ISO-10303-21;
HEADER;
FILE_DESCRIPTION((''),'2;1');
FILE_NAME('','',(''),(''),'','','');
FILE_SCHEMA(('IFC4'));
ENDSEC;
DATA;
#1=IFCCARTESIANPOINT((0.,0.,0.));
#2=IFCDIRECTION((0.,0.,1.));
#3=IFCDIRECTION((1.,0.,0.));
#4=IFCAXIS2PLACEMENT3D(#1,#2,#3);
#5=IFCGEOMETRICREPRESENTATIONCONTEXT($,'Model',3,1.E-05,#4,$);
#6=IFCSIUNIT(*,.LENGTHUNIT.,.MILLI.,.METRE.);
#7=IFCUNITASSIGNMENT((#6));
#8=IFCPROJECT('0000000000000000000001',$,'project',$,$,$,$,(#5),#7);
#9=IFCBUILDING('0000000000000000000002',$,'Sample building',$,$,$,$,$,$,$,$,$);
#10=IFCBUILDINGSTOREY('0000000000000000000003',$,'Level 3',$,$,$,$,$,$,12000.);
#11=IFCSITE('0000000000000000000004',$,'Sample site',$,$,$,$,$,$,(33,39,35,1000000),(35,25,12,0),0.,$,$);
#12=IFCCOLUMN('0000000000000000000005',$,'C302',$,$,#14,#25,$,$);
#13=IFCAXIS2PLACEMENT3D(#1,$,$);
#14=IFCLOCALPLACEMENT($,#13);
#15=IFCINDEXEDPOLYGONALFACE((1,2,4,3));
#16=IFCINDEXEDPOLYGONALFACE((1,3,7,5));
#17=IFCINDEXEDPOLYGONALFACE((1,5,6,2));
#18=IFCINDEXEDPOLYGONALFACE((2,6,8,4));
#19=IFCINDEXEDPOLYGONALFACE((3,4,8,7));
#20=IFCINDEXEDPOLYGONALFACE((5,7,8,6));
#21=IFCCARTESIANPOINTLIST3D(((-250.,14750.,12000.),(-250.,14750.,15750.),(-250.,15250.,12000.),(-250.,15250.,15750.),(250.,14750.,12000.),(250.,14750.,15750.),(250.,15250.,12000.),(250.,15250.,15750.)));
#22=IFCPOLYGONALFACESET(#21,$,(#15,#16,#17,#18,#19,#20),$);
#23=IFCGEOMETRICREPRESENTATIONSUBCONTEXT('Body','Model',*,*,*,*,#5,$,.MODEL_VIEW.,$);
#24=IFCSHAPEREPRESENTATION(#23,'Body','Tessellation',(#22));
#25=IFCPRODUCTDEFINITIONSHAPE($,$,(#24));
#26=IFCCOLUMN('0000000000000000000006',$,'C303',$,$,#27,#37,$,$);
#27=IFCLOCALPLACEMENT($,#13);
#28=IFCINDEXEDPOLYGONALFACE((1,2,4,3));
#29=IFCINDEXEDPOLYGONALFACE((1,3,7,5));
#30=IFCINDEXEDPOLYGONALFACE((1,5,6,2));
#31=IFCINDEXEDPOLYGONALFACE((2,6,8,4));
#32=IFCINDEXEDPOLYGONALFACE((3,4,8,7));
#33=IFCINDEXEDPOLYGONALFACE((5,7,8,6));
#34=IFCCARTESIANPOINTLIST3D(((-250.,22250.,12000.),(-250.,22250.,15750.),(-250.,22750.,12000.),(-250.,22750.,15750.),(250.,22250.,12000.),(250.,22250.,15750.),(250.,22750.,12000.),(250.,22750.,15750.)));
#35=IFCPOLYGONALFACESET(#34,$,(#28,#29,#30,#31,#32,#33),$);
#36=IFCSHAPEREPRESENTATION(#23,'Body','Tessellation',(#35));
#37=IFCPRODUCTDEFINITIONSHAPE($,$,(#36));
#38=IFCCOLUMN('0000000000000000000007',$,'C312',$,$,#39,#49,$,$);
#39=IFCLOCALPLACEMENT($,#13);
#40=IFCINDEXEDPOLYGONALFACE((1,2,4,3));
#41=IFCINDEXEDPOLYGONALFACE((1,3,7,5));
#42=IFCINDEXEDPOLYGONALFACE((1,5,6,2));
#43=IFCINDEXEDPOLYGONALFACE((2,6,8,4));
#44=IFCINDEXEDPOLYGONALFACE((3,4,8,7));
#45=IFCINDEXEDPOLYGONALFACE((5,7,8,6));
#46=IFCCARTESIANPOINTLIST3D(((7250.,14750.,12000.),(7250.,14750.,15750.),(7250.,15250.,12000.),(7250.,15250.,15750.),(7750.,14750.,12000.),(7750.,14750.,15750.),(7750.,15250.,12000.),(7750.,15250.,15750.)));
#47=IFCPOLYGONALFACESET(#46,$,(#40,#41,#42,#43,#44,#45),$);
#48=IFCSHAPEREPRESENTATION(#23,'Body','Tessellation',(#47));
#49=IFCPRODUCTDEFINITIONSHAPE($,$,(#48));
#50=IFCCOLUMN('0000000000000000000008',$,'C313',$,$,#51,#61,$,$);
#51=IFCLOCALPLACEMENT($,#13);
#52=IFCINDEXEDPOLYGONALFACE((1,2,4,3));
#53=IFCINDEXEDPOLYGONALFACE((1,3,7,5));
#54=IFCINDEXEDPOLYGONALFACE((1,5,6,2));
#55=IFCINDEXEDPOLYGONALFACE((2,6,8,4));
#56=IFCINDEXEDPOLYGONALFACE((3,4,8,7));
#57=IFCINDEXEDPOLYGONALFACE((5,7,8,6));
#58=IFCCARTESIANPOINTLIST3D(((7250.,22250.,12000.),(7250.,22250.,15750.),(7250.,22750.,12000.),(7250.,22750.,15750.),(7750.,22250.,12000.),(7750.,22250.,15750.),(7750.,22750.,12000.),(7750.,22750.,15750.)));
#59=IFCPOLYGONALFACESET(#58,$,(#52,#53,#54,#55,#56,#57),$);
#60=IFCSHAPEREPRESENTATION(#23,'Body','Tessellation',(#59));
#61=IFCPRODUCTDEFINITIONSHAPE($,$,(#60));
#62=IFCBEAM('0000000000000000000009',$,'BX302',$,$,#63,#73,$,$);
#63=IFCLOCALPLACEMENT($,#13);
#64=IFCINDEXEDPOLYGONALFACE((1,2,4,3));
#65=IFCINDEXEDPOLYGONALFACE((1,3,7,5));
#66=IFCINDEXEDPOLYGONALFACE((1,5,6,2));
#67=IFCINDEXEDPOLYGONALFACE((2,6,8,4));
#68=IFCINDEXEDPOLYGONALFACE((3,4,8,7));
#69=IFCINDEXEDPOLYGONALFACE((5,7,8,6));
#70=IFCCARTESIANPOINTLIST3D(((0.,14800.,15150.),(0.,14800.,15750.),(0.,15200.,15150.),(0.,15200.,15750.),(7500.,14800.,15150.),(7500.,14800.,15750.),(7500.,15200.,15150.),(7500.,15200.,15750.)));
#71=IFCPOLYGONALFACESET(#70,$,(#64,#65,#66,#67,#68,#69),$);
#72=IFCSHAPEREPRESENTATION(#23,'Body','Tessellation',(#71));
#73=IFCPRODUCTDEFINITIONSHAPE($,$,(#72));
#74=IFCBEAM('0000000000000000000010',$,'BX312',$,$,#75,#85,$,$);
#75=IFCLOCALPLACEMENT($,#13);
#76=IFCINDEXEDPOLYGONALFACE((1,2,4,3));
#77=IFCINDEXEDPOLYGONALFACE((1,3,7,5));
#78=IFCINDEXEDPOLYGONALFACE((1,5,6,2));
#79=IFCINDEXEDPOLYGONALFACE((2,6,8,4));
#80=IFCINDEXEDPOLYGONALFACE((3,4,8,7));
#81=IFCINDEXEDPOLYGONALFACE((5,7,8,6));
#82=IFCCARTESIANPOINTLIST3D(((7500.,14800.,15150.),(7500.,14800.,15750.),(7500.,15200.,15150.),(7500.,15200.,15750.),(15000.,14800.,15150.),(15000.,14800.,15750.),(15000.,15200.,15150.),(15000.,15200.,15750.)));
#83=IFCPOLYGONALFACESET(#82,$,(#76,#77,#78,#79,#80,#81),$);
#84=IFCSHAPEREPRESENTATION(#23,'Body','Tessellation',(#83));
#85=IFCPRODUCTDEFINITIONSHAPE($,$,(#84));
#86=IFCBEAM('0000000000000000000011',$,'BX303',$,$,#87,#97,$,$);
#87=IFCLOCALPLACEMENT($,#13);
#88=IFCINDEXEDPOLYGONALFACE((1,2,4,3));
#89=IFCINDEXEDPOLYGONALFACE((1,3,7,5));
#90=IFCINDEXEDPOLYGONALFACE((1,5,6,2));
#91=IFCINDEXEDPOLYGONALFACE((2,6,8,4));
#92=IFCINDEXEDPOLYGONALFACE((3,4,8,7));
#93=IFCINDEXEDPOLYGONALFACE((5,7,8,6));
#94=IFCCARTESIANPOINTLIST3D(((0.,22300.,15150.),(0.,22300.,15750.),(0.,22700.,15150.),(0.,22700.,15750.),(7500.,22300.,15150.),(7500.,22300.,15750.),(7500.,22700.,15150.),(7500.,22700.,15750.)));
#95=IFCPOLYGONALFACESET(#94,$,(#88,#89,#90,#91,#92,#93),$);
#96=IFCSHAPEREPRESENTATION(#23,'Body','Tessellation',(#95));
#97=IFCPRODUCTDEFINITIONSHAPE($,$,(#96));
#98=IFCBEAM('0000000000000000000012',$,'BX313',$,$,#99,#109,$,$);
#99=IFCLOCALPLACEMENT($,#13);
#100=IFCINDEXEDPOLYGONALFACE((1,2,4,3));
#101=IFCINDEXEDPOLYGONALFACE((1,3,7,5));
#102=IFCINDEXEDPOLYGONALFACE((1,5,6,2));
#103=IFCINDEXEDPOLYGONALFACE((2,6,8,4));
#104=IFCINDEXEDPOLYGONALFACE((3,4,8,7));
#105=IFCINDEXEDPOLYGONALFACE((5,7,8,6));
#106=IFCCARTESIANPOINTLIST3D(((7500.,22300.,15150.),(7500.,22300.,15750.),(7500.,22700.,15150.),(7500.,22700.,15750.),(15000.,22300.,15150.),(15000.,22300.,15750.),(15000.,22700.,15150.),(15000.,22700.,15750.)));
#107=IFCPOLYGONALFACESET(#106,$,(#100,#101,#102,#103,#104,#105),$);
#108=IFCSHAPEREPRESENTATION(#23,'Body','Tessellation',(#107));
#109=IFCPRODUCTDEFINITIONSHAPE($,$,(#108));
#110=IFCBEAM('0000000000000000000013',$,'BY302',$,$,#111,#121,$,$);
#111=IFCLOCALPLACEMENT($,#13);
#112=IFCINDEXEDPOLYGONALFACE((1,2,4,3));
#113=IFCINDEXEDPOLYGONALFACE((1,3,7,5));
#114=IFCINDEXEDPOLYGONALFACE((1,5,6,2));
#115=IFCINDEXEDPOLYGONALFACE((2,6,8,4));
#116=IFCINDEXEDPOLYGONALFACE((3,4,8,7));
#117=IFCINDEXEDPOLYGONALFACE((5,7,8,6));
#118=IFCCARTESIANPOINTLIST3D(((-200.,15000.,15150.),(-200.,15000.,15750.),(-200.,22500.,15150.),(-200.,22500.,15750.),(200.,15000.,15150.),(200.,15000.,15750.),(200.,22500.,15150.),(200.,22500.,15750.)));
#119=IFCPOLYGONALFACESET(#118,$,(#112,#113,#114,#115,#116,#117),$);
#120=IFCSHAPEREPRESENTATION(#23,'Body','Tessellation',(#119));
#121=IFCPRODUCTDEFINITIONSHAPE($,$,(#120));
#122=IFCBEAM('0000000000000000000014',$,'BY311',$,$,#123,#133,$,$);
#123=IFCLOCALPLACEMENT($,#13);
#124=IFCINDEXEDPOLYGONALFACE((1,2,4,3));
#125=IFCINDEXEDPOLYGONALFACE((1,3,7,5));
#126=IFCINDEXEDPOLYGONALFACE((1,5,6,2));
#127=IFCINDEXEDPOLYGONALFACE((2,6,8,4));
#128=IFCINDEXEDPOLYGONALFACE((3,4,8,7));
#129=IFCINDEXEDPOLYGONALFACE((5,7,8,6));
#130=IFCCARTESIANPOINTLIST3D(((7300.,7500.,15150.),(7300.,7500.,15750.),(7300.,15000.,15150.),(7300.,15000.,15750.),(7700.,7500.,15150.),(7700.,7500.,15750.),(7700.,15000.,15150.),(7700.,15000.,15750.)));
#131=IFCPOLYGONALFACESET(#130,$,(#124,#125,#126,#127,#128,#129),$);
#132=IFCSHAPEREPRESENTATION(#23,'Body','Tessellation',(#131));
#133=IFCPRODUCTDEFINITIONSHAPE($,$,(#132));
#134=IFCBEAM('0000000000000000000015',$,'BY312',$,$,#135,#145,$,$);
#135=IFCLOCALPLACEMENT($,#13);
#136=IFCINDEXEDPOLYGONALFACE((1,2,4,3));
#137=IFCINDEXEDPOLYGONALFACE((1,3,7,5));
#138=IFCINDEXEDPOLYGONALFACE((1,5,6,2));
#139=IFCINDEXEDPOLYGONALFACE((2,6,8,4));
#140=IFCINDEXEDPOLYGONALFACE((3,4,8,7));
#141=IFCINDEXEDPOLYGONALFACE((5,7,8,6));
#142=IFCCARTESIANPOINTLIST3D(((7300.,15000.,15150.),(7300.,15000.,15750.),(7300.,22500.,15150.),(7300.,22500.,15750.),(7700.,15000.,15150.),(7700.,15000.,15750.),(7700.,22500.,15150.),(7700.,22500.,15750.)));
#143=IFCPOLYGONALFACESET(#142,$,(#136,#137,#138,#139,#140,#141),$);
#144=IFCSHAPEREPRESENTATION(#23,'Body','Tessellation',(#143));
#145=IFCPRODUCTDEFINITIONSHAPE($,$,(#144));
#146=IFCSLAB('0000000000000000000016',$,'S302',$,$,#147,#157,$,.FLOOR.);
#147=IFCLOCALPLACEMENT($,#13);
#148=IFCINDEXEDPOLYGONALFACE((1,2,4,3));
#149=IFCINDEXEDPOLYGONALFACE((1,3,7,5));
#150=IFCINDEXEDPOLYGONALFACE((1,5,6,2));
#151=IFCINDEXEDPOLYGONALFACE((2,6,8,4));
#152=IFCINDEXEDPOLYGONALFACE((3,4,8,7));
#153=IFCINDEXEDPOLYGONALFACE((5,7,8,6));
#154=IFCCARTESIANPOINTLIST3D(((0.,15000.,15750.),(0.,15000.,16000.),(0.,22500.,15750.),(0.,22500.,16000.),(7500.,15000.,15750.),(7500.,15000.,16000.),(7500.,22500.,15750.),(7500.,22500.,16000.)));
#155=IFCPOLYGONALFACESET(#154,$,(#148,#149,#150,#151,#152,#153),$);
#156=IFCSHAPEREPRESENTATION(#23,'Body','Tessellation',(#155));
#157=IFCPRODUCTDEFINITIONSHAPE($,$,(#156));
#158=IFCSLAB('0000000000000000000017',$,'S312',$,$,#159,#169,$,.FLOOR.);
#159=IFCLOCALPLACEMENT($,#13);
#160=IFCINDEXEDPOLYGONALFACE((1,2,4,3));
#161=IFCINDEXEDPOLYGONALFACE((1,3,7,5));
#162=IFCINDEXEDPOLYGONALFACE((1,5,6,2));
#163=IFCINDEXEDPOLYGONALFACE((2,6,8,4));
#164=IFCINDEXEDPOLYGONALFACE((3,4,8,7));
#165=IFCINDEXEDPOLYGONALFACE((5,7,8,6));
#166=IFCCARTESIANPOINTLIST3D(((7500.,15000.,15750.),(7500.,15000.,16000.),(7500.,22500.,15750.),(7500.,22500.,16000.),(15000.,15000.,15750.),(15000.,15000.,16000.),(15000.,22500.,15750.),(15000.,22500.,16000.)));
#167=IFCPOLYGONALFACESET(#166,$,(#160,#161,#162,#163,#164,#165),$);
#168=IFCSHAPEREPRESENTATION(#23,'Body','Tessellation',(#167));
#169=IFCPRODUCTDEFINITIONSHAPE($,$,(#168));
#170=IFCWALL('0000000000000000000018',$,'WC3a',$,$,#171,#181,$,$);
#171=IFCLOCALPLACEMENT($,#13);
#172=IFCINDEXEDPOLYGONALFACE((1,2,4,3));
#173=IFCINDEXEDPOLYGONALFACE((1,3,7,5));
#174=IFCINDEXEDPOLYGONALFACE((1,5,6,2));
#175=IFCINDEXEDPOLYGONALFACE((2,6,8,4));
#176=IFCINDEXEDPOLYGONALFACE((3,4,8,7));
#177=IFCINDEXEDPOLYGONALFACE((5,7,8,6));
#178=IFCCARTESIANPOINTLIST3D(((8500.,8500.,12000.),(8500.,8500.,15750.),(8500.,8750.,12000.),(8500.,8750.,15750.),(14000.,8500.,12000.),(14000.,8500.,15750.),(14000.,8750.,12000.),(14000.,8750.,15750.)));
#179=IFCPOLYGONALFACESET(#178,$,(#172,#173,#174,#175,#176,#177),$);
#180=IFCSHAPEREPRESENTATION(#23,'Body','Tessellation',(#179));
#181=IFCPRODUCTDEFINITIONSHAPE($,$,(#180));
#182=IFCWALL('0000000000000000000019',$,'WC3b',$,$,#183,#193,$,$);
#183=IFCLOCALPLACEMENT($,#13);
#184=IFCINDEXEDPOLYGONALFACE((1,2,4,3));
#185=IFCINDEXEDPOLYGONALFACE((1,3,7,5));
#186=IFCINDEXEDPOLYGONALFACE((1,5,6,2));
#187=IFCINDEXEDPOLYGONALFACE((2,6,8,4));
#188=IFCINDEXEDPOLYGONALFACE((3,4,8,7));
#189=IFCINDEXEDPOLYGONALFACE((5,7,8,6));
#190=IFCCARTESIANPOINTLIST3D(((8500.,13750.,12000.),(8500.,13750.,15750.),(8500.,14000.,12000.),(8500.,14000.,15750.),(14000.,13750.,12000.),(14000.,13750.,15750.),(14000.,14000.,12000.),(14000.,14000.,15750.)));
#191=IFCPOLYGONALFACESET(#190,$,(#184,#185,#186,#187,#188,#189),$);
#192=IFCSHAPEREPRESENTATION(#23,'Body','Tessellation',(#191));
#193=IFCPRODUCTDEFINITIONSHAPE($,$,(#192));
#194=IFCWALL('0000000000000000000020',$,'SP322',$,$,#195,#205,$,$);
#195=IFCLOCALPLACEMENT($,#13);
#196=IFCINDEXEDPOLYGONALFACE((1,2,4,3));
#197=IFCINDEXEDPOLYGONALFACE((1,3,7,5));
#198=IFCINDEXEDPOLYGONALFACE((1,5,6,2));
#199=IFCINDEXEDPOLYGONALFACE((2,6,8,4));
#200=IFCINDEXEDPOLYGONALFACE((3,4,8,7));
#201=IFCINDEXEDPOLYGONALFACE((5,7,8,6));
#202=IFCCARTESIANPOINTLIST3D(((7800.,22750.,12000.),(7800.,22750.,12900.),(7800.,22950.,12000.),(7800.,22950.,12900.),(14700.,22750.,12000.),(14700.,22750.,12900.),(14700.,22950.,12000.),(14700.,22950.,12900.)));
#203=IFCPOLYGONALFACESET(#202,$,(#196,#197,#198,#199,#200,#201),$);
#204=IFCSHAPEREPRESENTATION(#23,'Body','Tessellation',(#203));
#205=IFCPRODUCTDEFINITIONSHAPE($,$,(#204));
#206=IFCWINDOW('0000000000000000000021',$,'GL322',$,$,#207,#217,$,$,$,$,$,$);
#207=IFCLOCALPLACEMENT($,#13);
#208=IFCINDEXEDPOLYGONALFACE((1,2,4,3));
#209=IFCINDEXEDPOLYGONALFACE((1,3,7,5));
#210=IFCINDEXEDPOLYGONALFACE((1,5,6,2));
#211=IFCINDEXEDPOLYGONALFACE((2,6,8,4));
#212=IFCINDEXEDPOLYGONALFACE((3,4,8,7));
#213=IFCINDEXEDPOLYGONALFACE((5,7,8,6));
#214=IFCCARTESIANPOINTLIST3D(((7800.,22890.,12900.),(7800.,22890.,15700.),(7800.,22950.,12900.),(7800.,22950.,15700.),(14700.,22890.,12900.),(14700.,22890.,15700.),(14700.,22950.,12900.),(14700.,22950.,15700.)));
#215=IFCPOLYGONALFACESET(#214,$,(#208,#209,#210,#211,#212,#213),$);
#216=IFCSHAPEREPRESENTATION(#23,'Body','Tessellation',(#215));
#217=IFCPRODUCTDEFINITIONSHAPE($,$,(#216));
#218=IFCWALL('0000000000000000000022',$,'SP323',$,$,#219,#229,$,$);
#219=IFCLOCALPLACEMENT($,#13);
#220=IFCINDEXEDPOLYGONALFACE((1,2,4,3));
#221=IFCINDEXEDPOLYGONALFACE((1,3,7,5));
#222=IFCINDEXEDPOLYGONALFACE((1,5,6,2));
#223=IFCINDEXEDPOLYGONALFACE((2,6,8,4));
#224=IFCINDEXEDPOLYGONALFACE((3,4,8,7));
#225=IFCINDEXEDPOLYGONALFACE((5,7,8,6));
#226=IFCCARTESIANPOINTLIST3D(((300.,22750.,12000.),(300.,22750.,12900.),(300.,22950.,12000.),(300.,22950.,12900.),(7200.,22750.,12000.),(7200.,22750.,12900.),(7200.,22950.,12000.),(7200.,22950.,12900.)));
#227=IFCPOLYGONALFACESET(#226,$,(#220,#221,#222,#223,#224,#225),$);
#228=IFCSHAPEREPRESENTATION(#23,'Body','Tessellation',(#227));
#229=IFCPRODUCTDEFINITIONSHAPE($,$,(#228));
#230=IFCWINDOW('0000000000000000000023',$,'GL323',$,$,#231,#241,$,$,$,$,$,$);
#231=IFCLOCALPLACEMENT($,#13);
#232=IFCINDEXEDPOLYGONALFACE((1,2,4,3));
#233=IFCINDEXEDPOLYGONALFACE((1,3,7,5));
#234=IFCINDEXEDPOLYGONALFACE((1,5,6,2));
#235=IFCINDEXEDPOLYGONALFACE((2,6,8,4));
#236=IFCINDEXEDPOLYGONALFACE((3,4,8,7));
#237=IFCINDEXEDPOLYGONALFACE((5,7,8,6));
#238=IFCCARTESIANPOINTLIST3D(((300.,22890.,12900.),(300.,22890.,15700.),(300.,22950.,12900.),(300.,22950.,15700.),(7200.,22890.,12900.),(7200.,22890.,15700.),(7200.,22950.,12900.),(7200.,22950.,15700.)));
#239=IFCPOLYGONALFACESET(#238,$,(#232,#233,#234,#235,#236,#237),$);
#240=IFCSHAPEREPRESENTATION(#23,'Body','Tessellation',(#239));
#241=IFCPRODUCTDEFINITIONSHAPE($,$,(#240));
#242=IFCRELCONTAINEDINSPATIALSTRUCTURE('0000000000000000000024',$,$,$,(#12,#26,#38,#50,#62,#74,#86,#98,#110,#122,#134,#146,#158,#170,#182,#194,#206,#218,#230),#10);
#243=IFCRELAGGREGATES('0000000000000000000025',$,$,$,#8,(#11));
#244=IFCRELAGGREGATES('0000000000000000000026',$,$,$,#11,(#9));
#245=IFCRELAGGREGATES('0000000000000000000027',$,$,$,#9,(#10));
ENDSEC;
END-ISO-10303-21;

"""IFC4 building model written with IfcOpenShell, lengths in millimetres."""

from ifc_helpers import new_model, si_unit, frame, origin_with_axes, place, context, subcontext, project, spatial, indexed_curve, outline, extrude, element, save


model = new_model("IFC4")

# Units and contexts
model_context = context("Model", 3, precision=1e-05, world=origin_with_axes())
body_context = subcontext(model_context, "Body", "Model", "MODEL_VIEW")
ifc_project = project(units=[si_unit("LENGTHUNIT", "METRE", prefix="MILLI")], contexts=[model_context])

# Site, building, storey
site = spatial("IfcSite", under=ifc_project, Name="Sample site", RefLatitude=(33, 39, 35, 1000000), RefLongitude=(35, 25, 12, 0), RefElevation=0.0)
building = spatial("IfcBuilding", under=site, Name="Sample building")
storey = spatial("IfcBuildingStorey", under=building, Name="Level 3", Elevation=12000.0)

# Columns
for number, where, z_axis, x_axis, name in (
    (1, (-250.0, 14750.0, 12000.0), (0.0, 0.0, 1.0), (1.0, 0.0, 0.0), "C302"),
    (2, (-250.0, 22250.0, 12000.0), (0.0, 0.0, 1.0), (1.0, 0.0, 0.0), "C303"),
    (3, (7250.0, 14750.0, 12000.0), (0.0, 0.0, 1.0), (1.0, 0.0, 0.0), "C312"),
    (4, (7250.0, 22250.0, 12000.0), (0.0, 0.0, 1.0), (1.0, 0.0, 0.0), "C313"),
):
    element("IfcColumn", number, at=place(None, frame(where, z_axis=z_axis, x_axis=x_axis)), inside=storey, Name=name, context=body_context, shape_type="SweptSolid", body=[
        extrude(outline(indexed_curve([(0.0, 0.0), (0.0, 500.0), (500.0, 500.0), (500.0, 0.0), (0.0, 0.0)], self_intersect=False)), origin_with_axes(), (0.0, 0.0, 1.0), 3750.0),
    ])

# Beams
for number, where, z_axis, x_axis, name in (
    (5, (0.0, 14800.0, 15150.0), (0.0, 0.0, 1.0), (1.0, 0.0, 0.0), "BX302"),
    (6, (7500.0, 14800.0, 15150.0), (0.0, 0.0, 1.0), (1.0, 0.0, 0.0), "BX312"),
    (7, (0.0, 22300.0, 15150.0), (0.0, 0.0, 1.0), (1.0, 0.0, 0.0), "BX303"),
    (8, (7500.0, 22300.0, 15150.0), (0.0, 0.0, 1.0), (1.0, 0.0, 0.0), "BX313"),
    (9, (200.0, 15000.0, 15150.0), (0.0, 0.0, 1.0), (0.0, 1.0, 0.0), "BY302"),
    (10, (7700.0, 7500.0, 15150.0), (0.0, 0.0, 1.0), (0.0, 1.0, 0.0), "BY311"),
    (11, (7700.0, 15000.0, 15150.0), (0.0, 0.0, 1.0), (0.0, 1.0, 0.0), "BY312"),
):
    element("IfcBeam", number, at=place(None, frame(where, z_axis=z_axis, x_axis=x_axis)), inside=storey, Name=name, context=body_context, shape_type="SweptSolid", body=[
        extrude(outline(indexed_curve([(0.0, 0.0), (0.0, 400.0), (7500.0, 400.0), (7500.0, 0.0), (0.0, 0.0)], self_intersect=False)), origin_with_axes(), (0.0, 0.0, 1.0), 600.0),
    ])

# Slabs
for number, where, z_axis, x_axis, name in (
    (12, (0.0, 15000.0, 15750.0), (0.0, 0.0, 1.0), (1.0, 0.0, 0.0), "S302"),
    (13, (7500.0, 15000.0, 15750.0), (0.0, 0.0, 1.0), (1.0, 0.0, 0.0), "S312"),
):
    element("IfcSlab", number, at=place(None, frame(where, z_axis=z_axis, x_axis=x_axis)), inside=storey, Name=name, PredefinedType="FLOOR", context=body_context, shape_type="SweptSolid", body=[
        extrude(outline(indexed_curve([(0.0, 0.0), (0.0, 7500.0), (7500.0, 7500.0), (7500.0, 0.0), (0.0, 0.0)], self_intersect=False)), origin_with_axes(), (0.0, 0.0, 1.0), 250.0),
    ])

# Walls
for number, where, z_axis, x_axis, name in (
    (14, (8500.0, 8500.0, 12000.0), (0.0, 0.0, 1.0), (1.0, 0.0, 0.0), "WC3a"),
    (15, (8500.0, 13750.0, 12000.0), (0.0, 0.0, 1.0), (1.0, 0.0, 0.0), "WC3b"),
):
    element("IfcWall", number, at=place(None, frame(where, z_axis=z_axis, x_axis=x_axis)), inside=storey, Name=name, context=body_context, shape_type="SweptSolid", body=[
        extrude(outline(indexed_curve([(0.0, 0.0), (0.0, 250.0), (5500.0, 250.0), (5500.0, 0.0), (0.0, 0.0)], self_intersect=False)), origin_with_axes(), (0.0, 0.0, 1.0), 3750.0),
    ])
wall_1_placement = place(None, frame((14700.0, 22950.0, 12000.0), z_axis=(0.0, 0.0, 1.0), x_axis=(-1.0, 0.0, 0.0)))
element("IfcWall", 16, at=wall_1_placement, inside=storey, Name="SP322", context=body_context, shape_type="SweptSolid", body=[
    extrude(outline(indexed_curve([(0.0, 0.0), (0.0, 200.0), (6900.0, 200.0), (6900.0, 0.0), (0.0, 0.0)], self_intersect=False)), origin_with_axes(), (0.0, 0.0, 1.0), 900.0),
])

# Window
window_1_placement = place(None, frame((14700.0, 22950.0, 12900.0), z_axis=(0.0, 0.0, 1.0), x_axis=(-1.0, 0.0, 0.0)))
element("IfcWindow", 17, at=window_1_placement, inside=storey, Name="GL322", context=body_context, shape_type="SweptSolid", body=[
    extrude(outline(indexed_curve([(0.0, 0.0), (0.0, 60.0), (6900.0, 60.0), (6900.0, 0.0), (0.0, 0.0)], self_intersect=False)), origin_with_axes(), (0.0, 0.0, 1.0), 2800.0),
])

# Wall
wall_2_placement = place(None, frame((7200.0, 22950.0, 12000.0), z_axis=(0.0, 0.0, 1.0), x_axis=(-1.0, 0.0, 0.0)))
element("IfcWall", 18, at=wall_2_placement, inside=storey, Name="SP323", context=body_context, shape_type="SweptSolid", body=[
    extrude(outline(indexed_curve([(0.0, 0.0), (0.0, 200.0), (6900.0, 200.0), (6900.0, 0.0), (0.0, 0.0)], self_intersect=False)), origin_with_axes(), (0.0, 0.0, 1.0), 900.0),
])

# Window
window_2_placement = place(None, frame((7200.0, 22950.0, 12900.0), z_axis=(0.0, 0.0, 1.0), x_axis=(-1.0, 0.0, 0.0)))
element("IfcWindow", 19, at=window_2_placement, inside=storey, Name="GL323", context=body_context, shape_type="SweptSolid", body=[
    extrude(outline(indexed_curve([(0.0, 0.0), (0.0, 60.0), (6900.0, 60.0), (6900.0, 0.0), (0.0, 0.0)], self_intersect=False)), origin_with_axes(), (0.0, 0.0, 1.0), 2800.0),
])

save(model, "model.ifc")
